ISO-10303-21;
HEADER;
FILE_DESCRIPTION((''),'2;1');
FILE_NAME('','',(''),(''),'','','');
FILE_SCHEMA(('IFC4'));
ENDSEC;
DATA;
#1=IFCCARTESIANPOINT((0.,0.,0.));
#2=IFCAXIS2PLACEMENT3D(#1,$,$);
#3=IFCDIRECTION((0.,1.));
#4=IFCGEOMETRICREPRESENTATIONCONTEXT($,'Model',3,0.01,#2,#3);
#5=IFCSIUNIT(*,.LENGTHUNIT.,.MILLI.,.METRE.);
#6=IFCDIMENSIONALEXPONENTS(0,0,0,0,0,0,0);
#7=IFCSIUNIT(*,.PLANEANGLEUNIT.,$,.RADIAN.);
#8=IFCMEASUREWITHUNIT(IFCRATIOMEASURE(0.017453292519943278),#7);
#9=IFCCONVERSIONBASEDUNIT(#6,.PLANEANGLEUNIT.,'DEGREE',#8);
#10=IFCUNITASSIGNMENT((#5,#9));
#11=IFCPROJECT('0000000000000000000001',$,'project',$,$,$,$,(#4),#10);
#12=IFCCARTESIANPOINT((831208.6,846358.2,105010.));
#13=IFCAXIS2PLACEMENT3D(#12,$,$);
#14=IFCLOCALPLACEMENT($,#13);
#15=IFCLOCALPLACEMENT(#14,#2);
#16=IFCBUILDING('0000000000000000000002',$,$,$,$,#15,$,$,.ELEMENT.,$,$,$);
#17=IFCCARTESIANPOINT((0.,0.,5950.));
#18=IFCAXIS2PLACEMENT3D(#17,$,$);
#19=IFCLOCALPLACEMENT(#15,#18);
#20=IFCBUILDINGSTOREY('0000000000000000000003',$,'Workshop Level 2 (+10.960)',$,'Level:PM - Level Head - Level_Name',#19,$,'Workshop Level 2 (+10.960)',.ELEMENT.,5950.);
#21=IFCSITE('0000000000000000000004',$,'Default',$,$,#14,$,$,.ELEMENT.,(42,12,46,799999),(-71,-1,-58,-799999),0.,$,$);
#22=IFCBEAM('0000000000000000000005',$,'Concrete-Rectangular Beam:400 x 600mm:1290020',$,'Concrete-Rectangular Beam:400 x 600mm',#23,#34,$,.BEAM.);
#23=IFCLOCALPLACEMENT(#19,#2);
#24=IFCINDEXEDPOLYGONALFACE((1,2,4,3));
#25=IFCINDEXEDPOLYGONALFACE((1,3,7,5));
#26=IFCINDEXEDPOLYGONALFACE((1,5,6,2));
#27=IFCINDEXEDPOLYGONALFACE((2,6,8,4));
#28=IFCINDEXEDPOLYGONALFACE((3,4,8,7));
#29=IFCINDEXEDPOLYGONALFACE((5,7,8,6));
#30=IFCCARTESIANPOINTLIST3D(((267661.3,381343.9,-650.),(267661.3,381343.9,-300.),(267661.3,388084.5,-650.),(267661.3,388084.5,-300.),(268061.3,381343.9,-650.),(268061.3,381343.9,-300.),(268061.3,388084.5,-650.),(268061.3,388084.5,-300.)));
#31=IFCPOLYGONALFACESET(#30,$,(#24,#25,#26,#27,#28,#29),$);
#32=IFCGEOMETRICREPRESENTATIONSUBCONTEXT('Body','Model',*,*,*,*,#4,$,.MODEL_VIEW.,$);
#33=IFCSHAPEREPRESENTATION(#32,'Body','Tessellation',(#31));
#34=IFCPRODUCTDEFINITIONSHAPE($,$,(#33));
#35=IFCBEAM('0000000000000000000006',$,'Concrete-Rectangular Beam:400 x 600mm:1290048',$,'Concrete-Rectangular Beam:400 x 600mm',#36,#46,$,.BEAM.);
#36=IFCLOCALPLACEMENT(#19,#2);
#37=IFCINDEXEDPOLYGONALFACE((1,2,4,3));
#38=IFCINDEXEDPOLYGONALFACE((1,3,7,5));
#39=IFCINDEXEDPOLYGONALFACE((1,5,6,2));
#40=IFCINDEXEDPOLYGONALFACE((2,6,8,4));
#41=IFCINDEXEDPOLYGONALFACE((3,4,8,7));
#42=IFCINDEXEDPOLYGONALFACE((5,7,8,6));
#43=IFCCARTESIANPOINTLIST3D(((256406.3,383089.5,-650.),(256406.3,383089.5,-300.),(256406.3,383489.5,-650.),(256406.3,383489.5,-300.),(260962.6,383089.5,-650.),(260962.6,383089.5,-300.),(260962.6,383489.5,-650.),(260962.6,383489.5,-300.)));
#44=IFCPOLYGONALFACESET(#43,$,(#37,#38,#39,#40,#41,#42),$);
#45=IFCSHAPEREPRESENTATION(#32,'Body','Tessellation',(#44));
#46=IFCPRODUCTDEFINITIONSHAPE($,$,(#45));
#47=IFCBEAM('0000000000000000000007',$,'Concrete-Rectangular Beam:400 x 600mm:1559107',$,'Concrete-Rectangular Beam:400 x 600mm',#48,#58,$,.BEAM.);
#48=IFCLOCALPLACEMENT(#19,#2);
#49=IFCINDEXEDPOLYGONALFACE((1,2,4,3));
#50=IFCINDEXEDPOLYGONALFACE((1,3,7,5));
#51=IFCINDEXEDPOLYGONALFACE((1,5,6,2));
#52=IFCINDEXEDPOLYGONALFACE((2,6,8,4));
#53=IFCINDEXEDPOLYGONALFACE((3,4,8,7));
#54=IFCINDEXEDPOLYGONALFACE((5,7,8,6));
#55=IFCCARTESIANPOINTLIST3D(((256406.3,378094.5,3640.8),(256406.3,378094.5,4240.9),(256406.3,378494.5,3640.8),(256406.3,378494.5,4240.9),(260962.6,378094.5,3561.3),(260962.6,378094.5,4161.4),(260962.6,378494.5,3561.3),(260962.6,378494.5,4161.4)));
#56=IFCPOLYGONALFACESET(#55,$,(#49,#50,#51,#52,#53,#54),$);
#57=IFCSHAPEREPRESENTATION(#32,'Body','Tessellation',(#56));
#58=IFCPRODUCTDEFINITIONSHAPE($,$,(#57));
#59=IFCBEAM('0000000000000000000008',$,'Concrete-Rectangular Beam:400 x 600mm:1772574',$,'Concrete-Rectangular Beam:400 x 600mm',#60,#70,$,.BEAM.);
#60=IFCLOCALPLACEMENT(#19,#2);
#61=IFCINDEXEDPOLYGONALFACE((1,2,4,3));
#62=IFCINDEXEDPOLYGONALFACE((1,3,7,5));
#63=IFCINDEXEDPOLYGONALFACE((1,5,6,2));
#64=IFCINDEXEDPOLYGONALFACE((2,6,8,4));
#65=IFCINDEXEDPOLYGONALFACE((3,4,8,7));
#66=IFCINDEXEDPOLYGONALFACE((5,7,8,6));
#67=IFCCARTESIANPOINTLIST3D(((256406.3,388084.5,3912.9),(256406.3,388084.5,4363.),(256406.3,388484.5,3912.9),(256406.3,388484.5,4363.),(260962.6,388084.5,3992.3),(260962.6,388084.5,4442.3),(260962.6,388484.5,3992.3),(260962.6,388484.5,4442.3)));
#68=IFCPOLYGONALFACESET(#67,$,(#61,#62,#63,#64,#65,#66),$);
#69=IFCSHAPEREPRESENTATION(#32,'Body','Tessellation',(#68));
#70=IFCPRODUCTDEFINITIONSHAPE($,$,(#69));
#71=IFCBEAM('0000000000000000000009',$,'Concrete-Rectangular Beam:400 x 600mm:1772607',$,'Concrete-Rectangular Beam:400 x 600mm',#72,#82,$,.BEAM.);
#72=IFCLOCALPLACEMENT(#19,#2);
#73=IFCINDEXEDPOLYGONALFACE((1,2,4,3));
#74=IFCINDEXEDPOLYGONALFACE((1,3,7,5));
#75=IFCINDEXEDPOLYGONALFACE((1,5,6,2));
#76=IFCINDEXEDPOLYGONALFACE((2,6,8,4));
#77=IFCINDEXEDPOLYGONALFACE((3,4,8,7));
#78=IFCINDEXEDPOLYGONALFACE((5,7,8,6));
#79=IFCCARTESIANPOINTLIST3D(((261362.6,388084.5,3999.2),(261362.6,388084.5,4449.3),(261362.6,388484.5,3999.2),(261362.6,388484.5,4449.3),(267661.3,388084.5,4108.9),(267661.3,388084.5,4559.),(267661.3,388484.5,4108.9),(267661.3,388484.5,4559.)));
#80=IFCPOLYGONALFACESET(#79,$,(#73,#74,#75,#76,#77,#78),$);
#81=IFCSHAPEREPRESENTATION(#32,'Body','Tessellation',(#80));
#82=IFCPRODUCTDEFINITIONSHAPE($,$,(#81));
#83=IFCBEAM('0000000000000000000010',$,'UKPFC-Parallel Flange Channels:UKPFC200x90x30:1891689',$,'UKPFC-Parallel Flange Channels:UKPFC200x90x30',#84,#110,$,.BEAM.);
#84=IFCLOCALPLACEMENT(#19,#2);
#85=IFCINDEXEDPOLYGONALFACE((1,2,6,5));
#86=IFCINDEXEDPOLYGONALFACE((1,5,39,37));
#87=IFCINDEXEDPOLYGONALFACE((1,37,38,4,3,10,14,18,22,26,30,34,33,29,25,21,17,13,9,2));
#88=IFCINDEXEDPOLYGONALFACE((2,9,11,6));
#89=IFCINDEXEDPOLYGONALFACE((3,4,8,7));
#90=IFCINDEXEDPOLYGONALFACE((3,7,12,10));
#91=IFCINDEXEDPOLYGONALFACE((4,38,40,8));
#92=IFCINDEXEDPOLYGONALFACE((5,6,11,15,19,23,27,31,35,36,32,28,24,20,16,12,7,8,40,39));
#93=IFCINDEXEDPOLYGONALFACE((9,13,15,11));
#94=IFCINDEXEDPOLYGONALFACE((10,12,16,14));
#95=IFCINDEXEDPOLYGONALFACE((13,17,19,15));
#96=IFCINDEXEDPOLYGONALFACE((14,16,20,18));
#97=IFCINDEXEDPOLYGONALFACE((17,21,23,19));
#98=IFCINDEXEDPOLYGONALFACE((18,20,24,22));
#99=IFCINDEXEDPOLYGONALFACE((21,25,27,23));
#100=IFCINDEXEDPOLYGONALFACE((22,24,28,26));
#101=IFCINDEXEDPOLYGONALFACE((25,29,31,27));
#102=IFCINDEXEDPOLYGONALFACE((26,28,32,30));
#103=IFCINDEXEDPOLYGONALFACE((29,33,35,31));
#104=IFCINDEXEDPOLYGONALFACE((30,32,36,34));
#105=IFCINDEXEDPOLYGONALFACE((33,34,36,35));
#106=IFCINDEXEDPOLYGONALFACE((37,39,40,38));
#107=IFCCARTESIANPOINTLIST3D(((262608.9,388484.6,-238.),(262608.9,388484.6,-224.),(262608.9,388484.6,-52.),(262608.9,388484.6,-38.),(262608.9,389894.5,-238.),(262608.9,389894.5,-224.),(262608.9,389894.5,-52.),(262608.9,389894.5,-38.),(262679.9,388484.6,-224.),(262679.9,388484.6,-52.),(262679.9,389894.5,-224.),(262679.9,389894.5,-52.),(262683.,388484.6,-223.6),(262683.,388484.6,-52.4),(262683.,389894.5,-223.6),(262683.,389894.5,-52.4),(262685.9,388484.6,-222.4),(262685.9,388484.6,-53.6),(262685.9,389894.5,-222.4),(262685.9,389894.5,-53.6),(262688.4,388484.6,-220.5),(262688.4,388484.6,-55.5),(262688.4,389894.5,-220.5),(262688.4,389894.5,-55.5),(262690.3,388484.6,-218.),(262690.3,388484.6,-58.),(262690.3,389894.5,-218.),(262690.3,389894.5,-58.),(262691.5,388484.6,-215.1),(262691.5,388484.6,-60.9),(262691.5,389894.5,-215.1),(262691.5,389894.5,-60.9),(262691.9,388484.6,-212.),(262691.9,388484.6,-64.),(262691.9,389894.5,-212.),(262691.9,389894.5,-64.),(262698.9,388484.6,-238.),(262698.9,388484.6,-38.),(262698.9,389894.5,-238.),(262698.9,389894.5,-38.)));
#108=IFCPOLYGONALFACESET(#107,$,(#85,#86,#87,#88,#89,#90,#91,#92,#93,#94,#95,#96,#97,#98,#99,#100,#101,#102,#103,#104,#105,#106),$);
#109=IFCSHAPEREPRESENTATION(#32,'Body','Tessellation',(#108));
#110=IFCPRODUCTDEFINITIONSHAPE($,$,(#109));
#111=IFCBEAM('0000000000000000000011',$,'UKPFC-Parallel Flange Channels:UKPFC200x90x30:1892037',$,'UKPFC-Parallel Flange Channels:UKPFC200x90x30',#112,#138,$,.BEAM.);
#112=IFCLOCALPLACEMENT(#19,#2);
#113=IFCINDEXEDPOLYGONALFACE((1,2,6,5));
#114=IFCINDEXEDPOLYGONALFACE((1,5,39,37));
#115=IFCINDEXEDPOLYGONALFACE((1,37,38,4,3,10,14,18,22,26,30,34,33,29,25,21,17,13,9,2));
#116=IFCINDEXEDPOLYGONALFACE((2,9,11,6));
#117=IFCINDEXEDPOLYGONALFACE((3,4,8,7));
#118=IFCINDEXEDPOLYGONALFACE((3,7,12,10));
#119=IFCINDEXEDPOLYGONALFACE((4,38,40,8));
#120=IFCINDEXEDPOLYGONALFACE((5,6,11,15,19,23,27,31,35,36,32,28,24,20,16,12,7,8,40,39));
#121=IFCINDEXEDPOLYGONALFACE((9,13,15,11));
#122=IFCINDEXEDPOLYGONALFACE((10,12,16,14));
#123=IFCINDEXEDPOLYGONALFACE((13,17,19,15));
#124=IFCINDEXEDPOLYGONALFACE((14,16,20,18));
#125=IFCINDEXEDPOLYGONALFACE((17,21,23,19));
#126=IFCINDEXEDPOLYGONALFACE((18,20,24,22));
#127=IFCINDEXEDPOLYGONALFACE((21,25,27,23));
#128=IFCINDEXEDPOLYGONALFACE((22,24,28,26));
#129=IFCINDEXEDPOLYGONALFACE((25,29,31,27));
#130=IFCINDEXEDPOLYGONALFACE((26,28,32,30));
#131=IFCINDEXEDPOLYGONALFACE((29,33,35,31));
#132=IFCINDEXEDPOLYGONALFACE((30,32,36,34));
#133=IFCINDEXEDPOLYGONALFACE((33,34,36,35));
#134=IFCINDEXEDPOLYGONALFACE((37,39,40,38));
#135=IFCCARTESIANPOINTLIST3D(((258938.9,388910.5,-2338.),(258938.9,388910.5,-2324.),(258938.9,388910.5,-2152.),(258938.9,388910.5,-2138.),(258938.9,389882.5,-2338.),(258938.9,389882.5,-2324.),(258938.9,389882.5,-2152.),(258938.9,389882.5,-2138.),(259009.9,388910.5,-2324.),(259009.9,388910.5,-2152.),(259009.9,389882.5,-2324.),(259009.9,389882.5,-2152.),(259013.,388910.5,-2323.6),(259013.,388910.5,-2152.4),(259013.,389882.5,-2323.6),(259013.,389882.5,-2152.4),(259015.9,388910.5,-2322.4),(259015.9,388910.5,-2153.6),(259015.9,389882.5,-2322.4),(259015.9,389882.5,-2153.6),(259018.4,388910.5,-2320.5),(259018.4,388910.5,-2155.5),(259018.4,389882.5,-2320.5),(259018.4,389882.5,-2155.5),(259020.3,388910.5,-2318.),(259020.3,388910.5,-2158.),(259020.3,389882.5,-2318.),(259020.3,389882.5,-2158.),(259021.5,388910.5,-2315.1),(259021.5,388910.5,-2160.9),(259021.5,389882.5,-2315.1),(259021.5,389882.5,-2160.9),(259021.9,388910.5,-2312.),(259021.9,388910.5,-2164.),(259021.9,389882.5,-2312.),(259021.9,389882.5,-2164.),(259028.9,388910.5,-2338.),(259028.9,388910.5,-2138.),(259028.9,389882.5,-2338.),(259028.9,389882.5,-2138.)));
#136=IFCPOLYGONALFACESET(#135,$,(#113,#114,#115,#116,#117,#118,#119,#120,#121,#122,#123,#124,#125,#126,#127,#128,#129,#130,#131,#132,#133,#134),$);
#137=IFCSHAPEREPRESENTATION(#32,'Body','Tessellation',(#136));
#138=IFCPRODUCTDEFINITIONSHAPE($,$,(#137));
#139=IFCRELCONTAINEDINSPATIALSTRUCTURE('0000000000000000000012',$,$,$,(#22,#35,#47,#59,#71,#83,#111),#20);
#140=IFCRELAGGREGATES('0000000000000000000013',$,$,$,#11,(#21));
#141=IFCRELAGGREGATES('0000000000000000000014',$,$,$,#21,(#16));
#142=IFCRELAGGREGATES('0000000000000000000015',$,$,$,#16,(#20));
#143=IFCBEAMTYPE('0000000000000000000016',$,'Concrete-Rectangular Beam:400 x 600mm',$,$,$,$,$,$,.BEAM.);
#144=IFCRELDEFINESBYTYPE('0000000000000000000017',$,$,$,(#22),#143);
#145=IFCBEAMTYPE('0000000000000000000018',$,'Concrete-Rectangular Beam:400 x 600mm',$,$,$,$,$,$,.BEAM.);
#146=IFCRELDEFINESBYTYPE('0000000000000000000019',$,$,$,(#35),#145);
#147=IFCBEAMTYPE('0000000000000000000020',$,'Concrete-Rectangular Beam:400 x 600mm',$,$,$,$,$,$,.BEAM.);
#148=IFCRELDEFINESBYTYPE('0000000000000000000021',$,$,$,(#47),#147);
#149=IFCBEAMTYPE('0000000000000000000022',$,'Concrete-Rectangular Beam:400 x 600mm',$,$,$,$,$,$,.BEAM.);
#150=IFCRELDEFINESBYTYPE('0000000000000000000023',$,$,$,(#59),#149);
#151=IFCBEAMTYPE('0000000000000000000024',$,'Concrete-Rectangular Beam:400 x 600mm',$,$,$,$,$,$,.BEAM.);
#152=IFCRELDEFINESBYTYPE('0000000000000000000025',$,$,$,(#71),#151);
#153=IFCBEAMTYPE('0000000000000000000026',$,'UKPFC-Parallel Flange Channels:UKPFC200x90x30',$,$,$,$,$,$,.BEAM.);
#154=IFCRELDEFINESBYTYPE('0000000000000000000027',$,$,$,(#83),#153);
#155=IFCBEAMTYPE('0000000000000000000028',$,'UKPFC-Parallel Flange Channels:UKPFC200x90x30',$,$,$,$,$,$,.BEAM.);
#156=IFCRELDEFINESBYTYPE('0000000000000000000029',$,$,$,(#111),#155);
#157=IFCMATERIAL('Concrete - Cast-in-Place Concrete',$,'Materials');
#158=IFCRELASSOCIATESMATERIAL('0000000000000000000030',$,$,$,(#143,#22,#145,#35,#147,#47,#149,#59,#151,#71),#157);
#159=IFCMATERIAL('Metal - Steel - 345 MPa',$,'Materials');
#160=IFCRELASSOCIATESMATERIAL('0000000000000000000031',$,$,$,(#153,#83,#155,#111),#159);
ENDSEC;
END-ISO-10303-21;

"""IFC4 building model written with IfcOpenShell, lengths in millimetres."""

from ifc_helpers import new_model, entity, si_unit, converted_unit, direction, frame, origin, place, context, subcontext, project, spatial, line, arc, indexed_curve, outline, extrude, source, transform, mapped, material, type_object, type_shapes, element, save


model = new_model("IFC4")

# Units and contexts
model_context = context("Model", 3, precision=0.01, world=origin(), true_north=direction((0.0, 1.0)))
body_context = subcontext(model_context, "Body", "Model", "MODEL_VIEW")
ifc_project = project(units=[si_unit("LENGTHUNIT", "METRE", prefix="MILLI"), converted_unit("PLANEANGLEUNIT", "DEGREE", entity("IfcRatioMeasure", 0.017453292519943278), si_unit("PLANEANGLEUNIT", "RADIAN"), dimensions=[0, 0, 0, 0, 0, 0, 0])], contexts=[model_context])

# Site, building, storey
site_placement = place(None, frame((831208.6, 846358.2, 105010.0)))
site = spatial("IfcSite", under=ifc_project, at=site_placement, Name="Default", CompositionType="ELEMENT", RefLatitude=(42, 12, 46, 799999), RefLongitude=(-71, -1, -58, -799999), RefElevation=0.0)
building_placement = place(site_placement, origin())
building = spatial("IfcBuilding", under=site, at=building_placement, CompositionType="ELEMENT")
storey_placement = place(building_placement, frame((0.0, 0.0, 5950.0)))
storey = spatial("IfcBuildingStorey", under=building, at=storey_placement, Name="Workshop Level 2 (+10.960)", ObjectType="Level:PM - Level Head - Level_Name", LongName="Workshop Level 2 (+10.960)", CompositionType="ELEMENT", Elevation=5950.0)

# Shared definitions
ifc_material_1 = material(Name="Concrete - Cast-in-Place Concrete", Category="Materials")

# Beams
beam_type_1 = type_object("IfcBeamType", Name="Concrete-Rectangular Beam:400 x 600mm", PredefinedType="BEAM", material=ifc_material_1)
shared_shape_1 = source(origin(), body_context, "Body", "SweptSolid", [
    extrude(outline(indexed_curve([(-200.0, -175.0), (200.0, -175.0), (200.0, 175.0), (-200.0, 175.0), (-200.0, -175.0)], self_intersect=False)), frame((267861.3, 388084.5, 5475.0), z_axis=(0.0, -1.0, 0.0), x_axis=(-1.0, 0.0, 0.0)), (0.0, 0.0, 1.0), 6740.6),
])
type_shapes(beam_type_1, [shared_shape_1])
beam_1_placement = place(storey_placement, frame((0.0, 0.0, -5950.0)))
element("IfcBeam", 1, at=beam_1_placement, inside=storey, type_object=beam_type_1, material=ifc_material_1, Name="Concrete-Rectangular Beam:400 x 600mm:1290020", ObjectType="Concrete-Rectangular Beam:400 x 600mm", PredefinedType="BEAM", context=body_context, shape_type="MappedRepresentation", body=[
    mapped(shared_shape_1, transform((0.0, 0.0, 0.0), scale=1.0)),
])
beam_type_2 = type_object("IfcBeamType", Name="Concrete-Rectangular Beam:400 x 600mm", PredefinedType="BEAM", material=ifc_material_1)
shared_shape_2 = source(origin(), body_context, "Body", "SweptSolid", [
    extrude(outline(indexed_curve([(-175.0, -200.0), (175.0, -200.0), (175.0, 200.0), (-175.0, 200.0), (-175.0, -200.0)], self_intersect=False)), frame((256406.3, 383289.5, 5475.0), z_axis=(1.0, 0.0, 0.0), x_axis=(0.0, 0.0, -1.0)), (0.0, 0.0, 1.0), 4556.3),
])
type_shapes(beam_type_2, [shared_shape_2])
beam_2_placement = place(storey_placement, frame((0.0, 0.0, -5950.0)))
element("IfcBeam", 2, at=beam_2_placement, inside=storey, type_object=beam_type_2, material=ifc_material_1, Name="Concrete-Rectangular Beam:400 x 600mm:1290048", ObjectType="Concrete-Rectangular Beam:400 x 600mm", PredefinedType="BEAM", context=body_context, shape_type="MappedRepresentation", body=[
    mapped(shared_shape_2, transform((0.0, 0.0, 0.0), scale=1.0)),
])
beam_type_3 = type_object("IfcBeamType", Name="Concrete-Rectangular Beam:400 x 600mm", PredefinedType="BEAM", material=ifc_material_1)
shared_shape_3 = source(origin(), body_context, "Body", "SweptSolid", [
    extrude(outline(indexed_curve([(-2283.7, -300.0), (2273.3, -300.0), (2283.7, 300.0), (-2273.3, 300.0), (-2283.7, -300.0)], self_intersect=False)), frame((258684.5, 378094.5, 9851.1), z_axis=(0.0, 1.0, 0.0), x_axis=(-0.999848, 0.0, 0.017452)), (0.0, 0.0, 1.0), 400.0),
])
type_shapes(beam_type_3, [shared_shape_3])
beam_3_placement = place(storey_placement, frame((0.0, 0.0, -5950.0)))
element("IfcBeam", 3, at=beam_3_placement, inside=storey, type_object=beam_type_3, material=ifc_material_1, Name="Concrete-Rectangular Beam:400 x 600mm:1559107", ObjectType="Concrete-Rectangular Beam:400 x 600mm", PredefinedType="BEAM", context=body_context, shape_type="MappedRepresentation", body=[
    mapped(shared_shape_3, transform((0.0, 0.0, 0.0), scale=1.0)),
])
beam_type_4 = type_object("IfcBeamType", Name="Concrete-Rectangular Beam:400 x 600mm", PredefinedType="BEAM", material=ifc_material_1)
shared_shape_4 = source(origin(), body_context, "Body", "SweptSolid", [
    extrude(outline(indexed_curve([(-264.7, -2278.2), (185.4, -2278.2), (264.7, 2278.2), (-185.4, 2278.2), (-264.7, -2278.2)], self_intersect=False)), frame((258684.5, 388084.5, 10127.6), z_axis=(0.0, 1.0, 0.0), x_axis=(0.0, 0.0, 1.0)), (0.0, 0.0, 1.0), 400.0),
])
type_shapes(beam_type_4, [shared_shape_4])
beam_4_placement = place(storey_placement, frame((0.0, 0.0, -5950.0)))
element("IfcBeam", 4, at=beam_4_placement, inside=storey, type_object=beam_type_4, material=ifc_material_1, Name="Concrete-Rectangular Beam:400 x 600mm:1772574", ObjectType="Concrete-Rectangular Beam:400 x 600mm", PredefinedType="BEAM", context=body_context, shape_type="MappedRepresentation", body=[
    mapped(shared_shape_4, transform((0.0, 0.0, 0.0), scale=1.0)),
])
beam_type_5 = type_object("IfcBeamType", Name="Concrete-Rectangular Beam:400 x 600mm", PredefinedType="BEAM", material=ifc_material_1)
shared_shape_5 = source(origin(), body_context, "Body", "SweptSolid", [
    extrude(outline(indexed_curve([(-279.9, -3149.3), (170.2, -3149.3), (279.9, 3149.3), (-170.2, 3149.3), (-279.9, -3149.3)], self_intersect=False)), frame((264512.0, 388084.5, 10229.1), z_axis=(0.0, 1.0, 0.0), x_axis=(0.0, 0.0, 1.0)), (0.0, 0.0, 1.0), 400.0),
])
type_shapes(beam_type_5, [shared_shape_5])
beam_5_placement = place(storey_placement, frame((0.0, 0.0, -5950.0)))
element("IfcBeam", 5, at=beam_5_placement, inside=storey, type_object=beam_type_5, material=ifc_material_1, Name="Concrete-Rectangular Beam:400 x 600mm:1772607", ObjectType="Concrete-Rectangular Beam:400 x 600mm", PredefinedType="BEAM", context=body_context, shape_type="MappedRepresentation", body=[
    mapped(shared_shape_5, transform((0.0, 0.0, 0.0), scale=1.0)),
])
ifc_material_2 = material(Name="Metal - Steel - 345 MPa", Category="Materials")
beam_type_6 = type_object("IfcBeamType", Name="UKPFC-Parallel Flange Channels:UKPFC200x90x30", PredefinedType="BEAM", material=ifc_material_2)
shared_shape_6 = source(origin(), body_context, "Body", "SweptSolid", [
    extrude(outline(indexed_curve([(-100.0, -41.2), (100.0, -41.2), (100.0, 48.8), (86.0, 48.8), (86.0, -22.2), (82.5, -30.7), (74.0, -34.2), (-74.0, -34.2), (-82.5, -30.7), (-86.0, -22.2), (-86.0, 48.8), (-100.0, 48.8)], segments=[line(1, 2, 3, 4, 5), arc(5, 6, 7), line(7, 8), arc(8, 9, 10), line(10, 11, 12, 1)], self_intersect=False)), frame((-738.8, 10.0, 0.0), z_axis=(1.0, 0.0, 0.0), x_axis=(0.0, 0.0, -1.0)), (0.0, 0.0, 1.0), 1409.9),
])
type_shapes(beam_type_6, [shared_shape_6])
beam_6_placement = place(storey_placement, frame((262667.7, 389223.4, -138.0), z_axis=(0.0, 0.0, 1.0), x_axis=(0.0, 1.0, 0.0)))
element("IfcBeam", 6, at=beam_6_placement, inside=storey, type_object=beam_type_6, material=ifc_material_2, Name="UKPFC-Parallel Flange Channels:UKPFC200x90x30:1891689", ObjectType="UKPFC-Parallel Flange Channels:UKPFC200x90x30", PredefinedType="BEAM", context=body_context, shape_type="MappedRepresentation", body=[
    mapped(shared_shape_6, transform((0.0, 0.0, 0.0), scale=1.0)),
])
beam_type_7 = type_object("IfcBeamType", Name="UKPFC-Parallel Flange Channels:UKPFC200x90x30", PredefinedType="BEAM", material=ifc_material_2)
shared_shape_7 = source(origin(), body_context, "Body", "SweptSolid", [
    extrude(outline(indexed_curve([(-100.0, -41.2), (100.0, -41.2), (100.0, 48.8), (86.0, 48.8), (86.0, -22.2), (82.5, -30.7), (74.0, -34.2), (-74.0, -34.2), (-82.5, -30.7), (-86.0, -22.2), (-86.0, 48.8), (-100.0, 48.8)], segments=[line(1, 2, 3, 4, 5), arc(5, 6, 7), line(7, 8), arc(8, 9, 10), line(10, 11, 12, 1)], self_intersect=False)), frame((-484.5, 10.0, 0.0), z_axis=(1.0, 0.0, 0.0), x_axis=(0.0, 0.0, -1.0)), (0.0, 0.0, 1.0), 972.0),
])
type_shapes(beam_type_7, [shared_shape_7])
beam_7_placement = place(storey_placement, frame((258997.7, 389395.0, -2238.0), z_axis=(0.0, 0.0, 1.0), x_axis=(0.0, 1.0, 0.0)))
element("IfcBeam", 7, at=beam_7_placement, inside=storey, type_object=beam_type_7, material=ifc_material_2, Name="UKPFC-Parallel Flange Channels:UKPFC200x90x30:1892037", ObjectType="UKPFC-Parallel Flange Channels:UKPFC200x90x30", PredefinedType="BEAM", context=body_context, shape_type="MappedRepresentation", body=[
    mapped(shared_shape_7, transform((0.0, 0.0, 0.0), scale=1.0)),
])

save(model, "model.ifc")
